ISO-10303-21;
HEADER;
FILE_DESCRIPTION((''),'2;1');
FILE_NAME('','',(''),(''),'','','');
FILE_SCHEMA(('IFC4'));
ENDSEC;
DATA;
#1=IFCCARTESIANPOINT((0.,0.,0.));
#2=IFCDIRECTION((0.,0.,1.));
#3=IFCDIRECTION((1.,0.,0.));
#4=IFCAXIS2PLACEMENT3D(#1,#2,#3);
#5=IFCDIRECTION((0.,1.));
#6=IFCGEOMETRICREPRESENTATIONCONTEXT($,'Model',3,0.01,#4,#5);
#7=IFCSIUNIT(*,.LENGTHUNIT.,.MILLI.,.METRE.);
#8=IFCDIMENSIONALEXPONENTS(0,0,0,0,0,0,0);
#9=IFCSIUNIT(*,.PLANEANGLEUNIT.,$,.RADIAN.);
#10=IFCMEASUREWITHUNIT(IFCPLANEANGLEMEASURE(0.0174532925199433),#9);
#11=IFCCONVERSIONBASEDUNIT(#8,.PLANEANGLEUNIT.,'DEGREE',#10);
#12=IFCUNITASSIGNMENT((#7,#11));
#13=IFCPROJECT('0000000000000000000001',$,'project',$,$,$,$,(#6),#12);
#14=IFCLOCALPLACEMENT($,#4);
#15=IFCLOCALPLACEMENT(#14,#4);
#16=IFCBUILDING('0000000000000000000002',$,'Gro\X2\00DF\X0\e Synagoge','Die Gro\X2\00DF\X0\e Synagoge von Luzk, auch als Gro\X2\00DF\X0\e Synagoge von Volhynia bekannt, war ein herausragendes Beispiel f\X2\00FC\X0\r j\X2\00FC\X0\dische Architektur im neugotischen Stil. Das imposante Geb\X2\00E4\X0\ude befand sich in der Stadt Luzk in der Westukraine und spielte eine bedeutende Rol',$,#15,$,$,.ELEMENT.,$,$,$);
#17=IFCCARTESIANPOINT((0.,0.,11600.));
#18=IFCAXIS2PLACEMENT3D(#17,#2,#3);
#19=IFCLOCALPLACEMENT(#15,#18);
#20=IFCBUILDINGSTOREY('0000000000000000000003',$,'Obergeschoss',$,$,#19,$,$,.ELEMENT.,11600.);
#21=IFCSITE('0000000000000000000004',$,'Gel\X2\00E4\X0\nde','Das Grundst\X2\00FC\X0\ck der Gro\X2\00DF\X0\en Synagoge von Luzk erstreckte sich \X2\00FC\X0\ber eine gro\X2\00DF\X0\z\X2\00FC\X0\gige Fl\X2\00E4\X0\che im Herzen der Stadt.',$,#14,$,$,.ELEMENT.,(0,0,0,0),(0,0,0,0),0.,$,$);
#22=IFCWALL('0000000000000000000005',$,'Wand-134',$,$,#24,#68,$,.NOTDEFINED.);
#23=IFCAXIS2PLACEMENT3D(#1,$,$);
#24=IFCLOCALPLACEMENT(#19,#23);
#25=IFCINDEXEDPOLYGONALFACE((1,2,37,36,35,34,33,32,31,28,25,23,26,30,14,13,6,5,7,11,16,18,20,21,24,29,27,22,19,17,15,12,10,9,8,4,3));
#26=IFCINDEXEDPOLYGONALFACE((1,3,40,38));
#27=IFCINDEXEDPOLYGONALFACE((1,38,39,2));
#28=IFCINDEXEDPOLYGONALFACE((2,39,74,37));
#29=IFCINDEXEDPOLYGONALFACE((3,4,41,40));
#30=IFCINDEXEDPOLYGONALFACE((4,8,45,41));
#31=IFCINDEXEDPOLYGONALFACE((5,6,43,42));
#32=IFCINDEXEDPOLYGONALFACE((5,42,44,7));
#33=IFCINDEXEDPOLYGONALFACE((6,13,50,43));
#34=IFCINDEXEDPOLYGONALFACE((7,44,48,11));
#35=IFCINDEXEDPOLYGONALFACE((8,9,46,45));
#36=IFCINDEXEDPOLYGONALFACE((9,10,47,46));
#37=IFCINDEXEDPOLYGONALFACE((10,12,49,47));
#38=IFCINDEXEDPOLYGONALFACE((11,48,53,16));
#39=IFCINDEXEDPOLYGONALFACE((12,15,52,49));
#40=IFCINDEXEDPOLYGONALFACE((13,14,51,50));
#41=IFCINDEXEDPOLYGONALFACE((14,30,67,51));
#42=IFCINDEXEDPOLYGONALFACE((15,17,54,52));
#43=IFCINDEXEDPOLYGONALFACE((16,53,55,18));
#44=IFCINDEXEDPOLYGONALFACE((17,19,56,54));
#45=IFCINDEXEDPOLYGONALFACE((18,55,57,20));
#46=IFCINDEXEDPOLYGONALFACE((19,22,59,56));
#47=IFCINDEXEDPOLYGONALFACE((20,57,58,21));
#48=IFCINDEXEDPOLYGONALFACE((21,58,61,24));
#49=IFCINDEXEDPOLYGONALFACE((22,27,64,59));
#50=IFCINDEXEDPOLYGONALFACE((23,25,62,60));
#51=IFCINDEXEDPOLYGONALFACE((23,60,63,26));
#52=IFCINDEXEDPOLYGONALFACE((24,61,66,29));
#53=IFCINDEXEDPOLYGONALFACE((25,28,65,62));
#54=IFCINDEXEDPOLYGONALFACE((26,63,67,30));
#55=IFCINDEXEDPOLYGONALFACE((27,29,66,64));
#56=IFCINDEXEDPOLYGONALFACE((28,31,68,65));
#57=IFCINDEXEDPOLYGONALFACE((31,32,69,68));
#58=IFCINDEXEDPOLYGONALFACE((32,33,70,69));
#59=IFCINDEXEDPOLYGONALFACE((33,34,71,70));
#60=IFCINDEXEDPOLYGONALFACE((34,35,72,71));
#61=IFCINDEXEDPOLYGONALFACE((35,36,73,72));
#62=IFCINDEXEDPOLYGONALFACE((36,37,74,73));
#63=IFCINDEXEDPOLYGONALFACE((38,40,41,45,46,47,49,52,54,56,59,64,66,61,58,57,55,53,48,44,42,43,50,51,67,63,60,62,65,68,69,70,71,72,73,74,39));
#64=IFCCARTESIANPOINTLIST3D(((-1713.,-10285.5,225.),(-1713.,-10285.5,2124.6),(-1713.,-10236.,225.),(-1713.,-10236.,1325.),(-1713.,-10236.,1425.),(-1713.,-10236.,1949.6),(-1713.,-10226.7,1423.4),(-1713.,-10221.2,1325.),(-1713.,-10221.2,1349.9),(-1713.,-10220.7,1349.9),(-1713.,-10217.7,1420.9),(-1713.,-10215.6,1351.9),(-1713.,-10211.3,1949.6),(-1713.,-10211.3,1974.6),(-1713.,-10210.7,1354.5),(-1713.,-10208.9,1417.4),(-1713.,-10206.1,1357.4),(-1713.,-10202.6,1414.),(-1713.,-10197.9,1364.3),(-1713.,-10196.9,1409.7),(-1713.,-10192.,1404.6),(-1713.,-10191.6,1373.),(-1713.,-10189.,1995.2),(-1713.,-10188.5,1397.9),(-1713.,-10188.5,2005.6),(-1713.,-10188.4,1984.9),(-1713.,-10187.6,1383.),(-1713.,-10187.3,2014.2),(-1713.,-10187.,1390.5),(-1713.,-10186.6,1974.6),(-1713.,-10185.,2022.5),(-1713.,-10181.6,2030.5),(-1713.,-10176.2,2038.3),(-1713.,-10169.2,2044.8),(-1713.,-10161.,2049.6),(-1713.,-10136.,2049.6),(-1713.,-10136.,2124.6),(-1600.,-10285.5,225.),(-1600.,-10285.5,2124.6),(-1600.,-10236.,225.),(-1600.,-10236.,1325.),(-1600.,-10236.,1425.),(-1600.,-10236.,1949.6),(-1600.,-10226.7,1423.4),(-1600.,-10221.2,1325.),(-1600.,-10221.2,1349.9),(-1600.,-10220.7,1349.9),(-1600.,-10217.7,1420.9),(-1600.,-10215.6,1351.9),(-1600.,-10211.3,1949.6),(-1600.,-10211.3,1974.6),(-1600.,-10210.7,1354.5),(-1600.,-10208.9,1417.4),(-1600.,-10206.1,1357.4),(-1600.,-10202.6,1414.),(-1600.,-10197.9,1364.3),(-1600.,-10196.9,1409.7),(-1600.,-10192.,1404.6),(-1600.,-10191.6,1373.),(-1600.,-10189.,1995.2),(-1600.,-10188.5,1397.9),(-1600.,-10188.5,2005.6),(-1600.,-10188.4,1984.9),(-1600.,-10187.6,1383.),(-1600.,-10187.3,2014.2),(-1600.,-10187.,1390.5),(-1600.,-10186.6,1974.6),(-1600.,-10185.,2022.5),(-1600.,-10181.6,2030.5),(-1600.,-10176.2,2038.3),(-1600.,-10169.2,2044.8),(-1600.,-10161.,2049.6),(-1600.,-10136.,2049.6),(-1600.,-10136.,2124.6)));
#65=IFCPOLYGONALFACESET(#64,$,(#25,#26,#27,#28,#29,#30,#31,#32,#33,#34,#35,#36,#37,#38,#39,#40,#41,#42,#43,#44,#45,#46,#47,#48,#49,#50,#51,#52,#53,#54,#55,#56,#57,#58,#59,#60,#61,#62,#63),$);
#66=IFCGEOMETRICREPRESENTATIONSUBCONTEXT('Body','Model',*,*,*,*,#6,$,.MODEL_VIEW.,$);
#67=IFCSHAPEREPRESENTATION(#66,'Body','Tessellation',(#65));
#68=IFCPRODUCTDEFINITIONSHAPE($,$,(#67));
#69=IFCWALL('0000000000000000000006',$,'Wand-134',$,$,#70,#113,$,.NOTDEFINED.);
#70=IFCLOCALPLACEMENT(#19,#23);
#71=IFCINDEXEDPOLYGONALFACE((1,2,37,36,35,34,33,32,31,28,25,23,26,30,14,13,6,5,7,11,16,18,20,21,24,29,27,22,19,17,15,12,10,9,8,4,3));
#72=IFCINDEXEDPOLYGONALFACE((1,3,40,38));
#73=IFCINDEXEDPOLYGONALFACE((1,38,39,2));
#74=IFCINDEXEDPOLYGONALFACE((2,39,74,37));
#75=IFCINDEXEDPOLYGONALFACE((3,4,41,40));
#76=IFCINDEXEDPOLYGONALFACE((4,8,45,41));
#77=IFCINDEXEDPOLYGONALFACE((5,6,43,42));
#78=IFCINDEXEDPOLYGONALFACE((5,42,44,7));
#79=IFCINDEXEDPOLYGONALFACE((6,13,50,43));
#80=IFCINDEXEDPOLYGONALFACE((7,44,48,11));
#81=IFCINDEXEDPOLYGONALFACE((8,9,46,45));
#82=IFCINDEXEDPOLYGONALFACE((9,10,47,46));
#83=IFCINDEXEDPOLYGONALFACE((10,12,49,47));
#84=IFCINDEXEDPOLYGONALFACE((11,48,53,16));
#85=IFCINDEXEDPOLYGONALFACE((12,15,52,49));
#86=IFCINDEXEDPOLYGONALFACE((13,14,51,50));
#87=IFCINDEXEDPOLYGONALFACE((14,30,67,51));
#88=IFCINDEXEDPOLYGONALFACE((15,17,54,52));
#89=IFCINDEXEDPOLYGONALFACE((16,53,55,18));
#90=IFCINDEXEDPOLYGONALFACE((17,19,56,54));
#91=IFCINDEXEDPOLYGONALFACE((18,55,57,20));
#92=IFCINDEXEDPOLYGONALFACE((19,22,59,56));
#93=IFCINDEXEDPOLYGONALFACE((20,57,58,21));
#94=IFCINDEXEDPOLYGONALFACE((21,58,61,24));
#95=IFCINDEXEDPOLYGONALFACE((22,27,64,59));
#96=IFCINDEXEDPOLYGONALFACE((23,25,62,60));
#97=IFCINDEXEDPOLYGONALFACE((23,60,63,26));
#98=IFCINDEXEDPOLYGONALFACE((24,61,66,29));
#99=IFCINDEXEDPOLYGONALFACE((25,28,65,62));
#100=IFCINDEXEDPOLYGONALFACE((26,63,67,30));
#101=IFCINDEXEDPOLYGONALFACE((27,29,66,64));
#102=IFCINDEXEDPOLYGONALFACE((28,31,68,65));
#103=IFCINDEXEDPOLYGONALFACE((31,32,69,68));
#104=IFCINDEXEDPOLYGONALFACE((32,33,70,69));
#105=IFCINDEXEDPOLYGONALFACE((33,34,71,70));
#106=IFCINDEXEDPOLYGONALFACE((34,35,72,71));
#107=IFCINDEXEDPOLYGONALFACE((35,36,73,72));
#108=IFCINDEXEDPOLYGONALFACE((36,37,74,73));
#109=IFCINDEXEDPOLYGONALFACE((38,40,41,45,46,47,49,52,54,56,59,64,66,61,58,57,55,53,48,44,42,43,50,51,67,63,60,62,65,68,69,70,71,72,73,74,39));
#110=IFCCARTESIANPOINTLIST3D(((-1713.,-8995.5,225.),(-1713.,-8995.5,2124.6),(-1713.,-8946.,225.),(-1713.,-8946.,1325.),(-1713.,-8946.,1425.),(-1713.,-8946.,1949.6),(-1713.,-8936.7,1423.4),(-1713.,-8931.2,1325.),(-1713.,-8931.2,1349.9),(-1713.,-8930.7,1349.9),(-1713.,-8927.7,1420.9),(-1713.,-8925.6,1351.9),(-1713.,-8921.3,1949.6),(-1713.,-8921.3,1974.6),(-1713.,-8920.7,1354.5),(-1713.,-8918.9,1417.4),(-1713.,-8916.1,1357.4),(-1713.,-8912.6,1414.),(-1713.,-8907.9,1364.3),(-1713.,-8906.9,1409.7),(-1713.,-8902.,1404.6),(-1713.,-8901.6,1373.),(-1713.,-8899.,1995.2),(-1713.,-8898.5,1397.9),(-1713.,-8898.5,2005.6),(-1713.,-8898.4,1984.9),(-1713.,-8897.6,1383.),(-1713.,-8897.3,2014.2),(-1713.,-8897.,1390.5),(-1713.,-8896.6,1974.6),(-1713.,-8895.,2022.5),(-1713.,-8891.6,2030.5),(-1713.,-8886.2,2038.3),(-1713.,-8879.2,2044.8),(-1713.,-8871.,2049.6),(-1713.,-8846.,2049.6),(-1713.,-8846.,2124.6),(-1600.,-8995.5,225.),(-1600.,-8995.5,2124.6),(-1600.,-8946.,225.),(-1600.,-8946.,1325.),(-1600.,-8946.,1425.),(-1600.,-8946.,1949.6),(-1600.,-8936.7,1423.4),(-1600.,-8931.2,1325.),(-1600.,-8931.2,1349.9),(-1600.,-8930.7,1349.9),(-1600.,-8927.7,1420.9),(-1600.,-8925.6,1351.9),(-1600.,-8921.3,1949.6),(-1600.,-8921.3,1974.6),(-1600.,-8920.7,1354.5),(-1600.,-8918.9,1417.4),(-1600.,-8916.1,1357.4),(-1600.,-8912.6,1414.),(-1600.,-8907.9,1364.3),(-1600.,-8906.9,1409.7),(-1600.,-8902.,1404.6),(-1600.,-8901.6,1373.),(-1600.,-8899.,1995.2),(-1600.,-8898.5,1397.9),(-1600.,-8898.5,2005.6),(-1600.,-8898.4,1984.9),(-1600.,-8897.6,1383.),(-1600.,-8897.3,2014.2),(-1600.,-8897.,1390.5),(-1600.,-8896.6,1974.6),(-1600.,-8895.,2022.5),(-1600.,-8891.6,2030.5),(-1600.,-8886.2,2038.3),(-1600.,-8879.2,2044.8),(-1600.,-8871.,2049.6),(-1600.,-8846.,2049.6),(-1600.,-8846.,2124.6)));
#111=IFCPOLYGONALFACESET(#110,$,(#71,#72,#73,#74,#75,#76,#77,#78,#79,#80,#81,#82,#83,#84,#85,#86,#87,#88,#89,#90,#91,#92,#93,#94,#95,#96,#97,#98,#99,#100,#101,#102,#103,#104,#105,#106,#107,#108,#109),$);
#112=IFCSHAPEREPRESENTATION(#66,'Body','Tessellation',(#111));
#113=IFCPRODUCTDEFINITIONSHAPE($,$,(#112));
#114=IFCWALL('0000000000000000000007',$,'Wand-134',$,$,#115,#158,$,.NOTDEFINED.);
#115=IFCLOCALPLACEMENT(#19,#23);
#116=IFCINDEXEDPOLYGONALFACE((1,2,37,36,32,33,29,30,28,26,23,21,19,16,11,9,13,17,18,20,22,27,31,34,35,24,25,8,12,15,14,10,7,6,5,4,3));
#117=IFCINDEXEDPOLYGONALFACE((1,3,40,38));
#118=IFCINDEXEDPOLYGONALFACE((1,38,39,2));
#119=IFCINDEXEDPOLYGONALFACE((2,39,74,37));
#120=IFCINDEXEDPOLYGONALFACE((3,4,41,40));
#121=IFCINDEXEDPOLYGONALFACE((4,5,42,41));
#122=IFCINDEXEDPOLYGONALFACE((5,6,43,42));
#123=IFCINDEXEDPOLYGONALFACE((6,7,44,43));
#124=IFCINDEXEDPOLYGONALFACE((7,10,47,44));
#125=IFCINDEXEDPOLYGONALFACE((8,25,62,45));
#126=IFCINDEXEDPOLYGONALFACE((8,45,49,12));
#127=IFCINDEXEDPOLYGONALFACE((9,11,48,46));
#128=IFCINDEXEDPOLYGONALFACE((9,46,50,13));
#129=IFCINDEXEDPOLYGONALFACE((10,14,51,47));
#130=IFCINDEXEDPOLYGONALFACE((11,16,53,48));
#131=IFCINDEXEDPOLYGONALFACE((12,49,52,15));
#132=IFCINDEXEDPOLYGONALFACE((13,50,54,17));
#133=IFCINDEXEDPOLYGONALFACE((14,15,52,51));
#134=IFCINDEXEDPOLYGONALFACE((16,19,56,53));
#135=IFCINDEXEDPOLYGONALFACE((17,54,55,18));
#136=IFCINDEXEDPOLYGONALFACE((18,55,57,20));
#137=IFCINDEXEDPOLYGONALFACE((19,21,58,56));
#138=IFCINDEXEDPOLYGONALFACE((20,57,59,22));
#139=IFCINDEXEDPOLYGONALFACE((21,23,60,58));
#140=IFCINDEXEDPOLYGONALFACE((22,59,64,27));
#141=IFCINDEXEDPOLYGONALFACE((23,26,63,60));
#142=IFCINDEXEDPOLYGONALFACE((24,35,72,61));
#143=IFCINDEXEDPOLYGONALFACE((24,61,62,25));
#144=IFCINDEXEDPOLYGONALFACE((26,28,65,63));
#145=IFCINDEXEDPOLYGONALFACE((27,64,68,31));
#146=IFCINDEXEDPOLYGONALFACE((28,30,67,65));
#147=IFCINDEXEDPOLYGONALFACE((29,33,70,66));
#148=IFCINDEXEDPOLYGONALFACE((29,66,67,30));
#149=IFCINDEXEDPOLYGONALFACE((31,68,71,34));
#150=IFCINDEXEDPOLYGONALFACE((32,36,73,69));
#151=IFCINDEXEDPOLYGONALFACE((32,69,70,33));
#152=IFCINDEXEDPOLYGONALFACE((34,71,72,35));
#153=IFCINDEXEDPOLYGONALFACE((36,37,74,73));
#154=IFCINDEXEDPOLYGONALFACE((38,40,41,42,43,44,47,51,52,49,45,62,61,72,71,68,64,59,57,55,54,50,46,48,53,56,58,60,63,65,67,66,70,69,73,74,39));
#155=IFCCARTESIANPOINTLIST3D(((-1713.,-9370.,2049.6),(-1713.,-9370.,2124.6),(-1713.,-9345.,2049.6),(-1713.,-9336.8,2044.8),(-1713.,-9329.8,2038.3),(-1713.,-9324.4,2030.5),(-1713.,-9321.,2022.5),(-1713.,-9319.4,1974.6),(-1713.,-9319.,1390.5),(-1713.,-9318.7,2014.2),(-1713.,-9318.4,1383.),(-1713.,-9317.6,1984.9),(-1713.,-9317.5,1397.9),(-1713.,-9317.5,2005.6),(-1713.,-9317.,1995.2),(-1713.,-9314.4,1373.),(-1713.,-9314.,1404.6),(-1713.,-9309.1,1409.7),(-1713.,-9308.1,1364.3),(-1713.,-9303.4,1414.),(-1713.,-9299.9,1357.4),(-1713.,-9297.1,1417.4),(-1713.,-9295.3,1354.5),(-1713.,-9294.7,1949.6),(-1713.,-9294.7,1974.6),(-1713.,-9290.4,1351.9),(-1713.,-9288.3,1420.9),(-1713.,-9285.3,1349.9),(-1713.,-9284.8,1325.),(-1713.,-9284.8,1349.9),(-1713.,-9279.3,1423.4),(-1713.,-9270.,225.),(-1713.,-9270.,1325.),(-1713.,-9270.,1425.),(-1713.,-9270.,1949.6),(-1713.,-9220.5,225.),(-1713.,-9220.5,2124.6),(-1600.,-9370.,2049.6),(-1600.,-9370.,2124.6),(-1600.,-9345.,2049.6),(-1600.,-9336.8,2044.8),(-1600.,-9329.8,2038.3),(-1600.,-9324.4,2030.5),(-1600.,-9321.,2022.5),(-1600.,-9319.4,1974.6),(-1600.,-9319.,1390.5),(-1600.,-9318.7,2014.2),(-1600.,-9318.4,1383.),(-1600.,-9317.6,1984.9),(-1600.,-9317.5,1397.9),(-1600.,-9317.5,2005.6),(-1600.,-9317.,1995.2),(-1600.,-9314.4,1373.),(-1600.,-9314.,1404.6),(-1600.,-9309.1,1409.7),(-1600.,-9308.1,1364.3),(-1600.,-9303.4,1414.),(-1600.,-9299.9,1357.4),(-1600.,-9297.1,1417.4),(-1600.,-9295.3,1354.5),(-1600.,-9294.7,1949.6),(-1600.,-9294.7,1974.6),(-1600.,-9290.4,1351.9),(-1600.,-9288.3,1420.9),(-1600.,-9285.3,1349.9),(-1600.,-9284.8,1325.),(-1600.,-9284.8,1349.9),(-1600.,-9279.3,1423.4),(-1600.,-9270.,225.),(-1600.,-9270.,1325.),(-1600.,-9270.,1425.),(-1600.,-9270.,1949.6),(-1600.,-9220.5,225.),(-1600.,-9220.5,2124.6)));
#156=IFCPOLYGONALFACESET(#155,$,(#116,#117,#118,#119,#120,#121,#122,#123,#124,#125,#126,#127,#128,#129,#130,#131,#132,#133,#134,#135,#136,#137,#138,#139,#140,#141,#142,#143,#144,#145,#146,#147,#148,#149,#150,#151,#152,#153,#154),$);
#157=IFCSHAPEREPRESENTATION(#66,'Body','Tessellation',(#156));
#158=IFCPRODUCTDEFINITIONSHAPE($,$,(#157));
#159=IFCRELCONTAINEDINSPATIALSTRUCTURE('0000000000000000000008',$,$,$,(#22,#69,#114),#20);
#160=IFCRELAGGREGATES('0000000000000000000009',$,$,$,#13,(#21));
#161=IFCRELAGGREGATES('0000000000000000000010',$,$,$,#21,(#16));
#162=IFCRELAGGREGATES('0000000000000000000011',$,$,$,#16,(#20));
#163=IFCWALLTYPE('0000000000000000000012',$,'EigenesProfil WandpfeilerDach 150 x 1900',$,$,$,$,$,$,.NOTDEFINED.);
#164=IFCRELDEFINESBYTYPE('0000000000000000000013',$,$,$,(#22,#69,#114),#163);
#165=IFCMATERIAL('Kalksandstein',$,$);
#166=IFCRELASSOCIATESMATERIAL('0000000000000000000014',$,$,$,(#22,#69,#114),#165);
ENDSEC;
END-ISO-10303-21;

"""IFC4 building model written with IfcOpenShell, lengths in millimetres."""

from ifc_helpers import new_model, entity, si_unit, converted_unit, direction, frame, origin_with_axes, place, context, subcontext, project, spatial, line, arc, indexed_curve, outline, extrude, material, material_profile, profile_set, type_object, element, save


model = new_model("IFC4")

# Units and contexts
model_context = context("Model", 3, precision=0.01, world=origin_with_axes(), true_north=direction((0.0, 1.0)))
body_context = subcontext(model_context, "Body", "Model", "MODEL_VIEW")
ifc_project = project(units=[si_unit("LENGTHUNIT", "METRE", prefix="MILLI"), converted_unit("PLANEANGLEUNIT", "DEGREE", entity("IfcPlaneAngleMeasure", 0.0174532925199433), si_unit("PLANEANGLEUNIT", "RADIAN"), dimensions=[0, 0, 0, 0, 0, 0, 0])], contexts=[model_context])

# Site, building, storey
site_placement = place(None, origin_with_axes())
site = spatial("IfcSite", under=ifc_project, at=site_placement, Name="Gelände", Description="Das Grundstück der Großen Synagoge von Luzk erstreckte sich über eine großzügige Fläche im Herzen der Stadt.", CompositionType="ELEMENT", RefLatitude=(0, 0, 0, 0), RefLongitude=(0, 0, 0, 0), RefElevation=0.0)
building_placement = place(site_placement, origin_with_axes())
building = spatial("IfcBuilding", under=site, at=building_placement, Name="Große Synagoge", Description="Die Große Synagoge von Luzk, auch als Große Synagoge von Volhynia bekannt, war ein herausragendes Beispiel für jüdische Architektur im neugotischen Stil. Das imposante Gebäude befand sich in der Stadt Luzk in der Westukraine und spielte eine bedeutende Rol", CompositionType="ELEMENT")
storey_placement = place(building_placement, frame((0.0, 0.0, 11600.0), z_axis=(0.0, 0.0, 1.0), x_axis=(1.0, 0.0, 0.0)))
storey = spatial("IfcBuildingStorey", under=building, at=storey_placement, Name="Obergeschoss", CompositionType="ELEMENT", Elevation=11600.0)

# Walls
ifc_material_1 = material(Name="Kalksandstein")
ifc_material_profile = material_profile(ifc_material_1, outline(indexed_curve([(74.2, 1749.6), (98.9, 1749.6), (96.7, 1765.0), (97.0, 1780.5), (99.2, 1793.4), (103.9, 1805.5), (112.6, 1816.7), (124.5, 1824.6), (149.5, 1824.6), (149.5, 1899.6), (0.0, 1899.6), (0.0, 0.0), (49.5, 0.0), (49.5, 1100.0), (64.3, 1100.0), (64.3, 1124.9), (64.8, 1124.9), (72.4, 1128.1), (79.4, 1132.4), (91.1, 1143.4), (97.9, 1157.9), (98.0, 1169.2), (93.5, 1179.5), (85.8, 1187.0), (76.6, 1192.3), (63.3, 1197.2), (49.5, 1200.0), (49.5, 1724.6), (74.2, 1724.6)], segments=[line(1, 2), arc(2, 3, 4), arc(4, 5, 6), arc(6, 7, 8), line(8, 9, 10, 11, 12, 13, 14, 15, 16, 17), arc(17, 18, 19), arc(19, 20, 21), arc(21, 22, 23), arc(23, 24, 25), arc(25, 26, 27), line(27, 28, 29, 1)])), Name="Kalksandstein")
ifc_profile_set = profile_set([ifc_material_profile], Name="EigenesProfil WandpfeilerDach")
wall_type_1 = type_object("IfcWallType", Name="EigenesProfil WandpfeilerDach 150 x 1900", PredefinedType="NOTDEFINED")
for number, where, z_axis, x_axis, name in (
    (1, (-1713.0, -10285.5, 225.0), (0.0, 0.0, 1.0), (1.0, 0.0, 0.0), "Wand-134"),
    (2, (-1713.0, -8995.5, 225.0), (0.0, 0.0, 1.0), (1.0, 0.0, 0.0), "Wand-134"),
):
    element("IfcWall", number, at=place(storey_placement, frame(where, z_axis=z_axis, x_axis=x_axis)), inside=storey, type_object=wall_type_1, material=ifc_profile_set, Name=name, PredefinedType="NOTDEFINED", context=body_context, shape_type="SweptSolid", body=[
        extrude(outline(indexed_curve([(74.2, 1749.6), (98.9, 1749.6), (96.7, 1765.0), (97.0, 1780.5), (99.2, 1793.4), (103.9, 1805.5), (112.6, 1816.7), (124.5, 1824.6), (149.5, 1824.6), (149.5, 1899.6), (0.0, 1899.6), (0.0, 0.0), (49.5, 0.0), (49.5, 1100.0), (64.3, 1100.0), (64.3, 1124.9), (64.8, 1124.9), (72.4, 1128.1), (79.4, 1132.4), (91.1, 1143.4), (97.9, 1157.9), (98.0, 1169.2), (93.5, 1179.5), (85.8, 1187.0), (76.6, 1192.3), (63.3, 1197.2), (49.5, 1200.0), (49.5, 1724.6), (74.2, 1724.6)], segments=[line(1, 2), arc(2, 3, 4), arc(4, 5, 6), arc(6, 7, 8), line(8, 9, 10, 11, 12, 13, 14, 15, 16, 17), arc(17, 18, 19), arc(19, 20, 21), arc(21, 22, 23), arc(23, 24, 25), arc(25, 26, 27), line(27, 28, 29, 1)])), frame((0.0, 0.0, 0.0), z_axis=(1.0, 0.0, 0.0), x_axis=(0.0, 1.0, 0.0)), (0.0, 0.0, 1.0), 113.0),
    ])
wall_1_placement = place(storey_placement, frame((-1713.0, -9220.5, 225.0), z_axis=(0.0, 0.0, 1.0), x_axis=(1.0, 0.0, 0.0)))
element("IfcWall", 3, at=wall_1_placement, inside=storey, type_object=wall_type_1, material=ifc_profile_set, Name="Wand-134", PredefinedType="NOTDEFINED", context=body_context, shape_type="SweptSolid", body=[
    extrude(outline(indexed_curve([(74.2, 1749.6), (98.9, 1749.6), (96.7, 1765.0), (97.0, 1780.5), (99.2, 1793.4), (103.9, 1805.5), (112.6, 1816.7), (124.5, 1824.6), (149.5, 1824.6), (149.5, 1899.6), (0.0, 1899.6), (0.0, 0.0), (49.5, 0.0), (49.5, 1100.0), (64.3, 1100.0), (64.3, 1124.9), (64.8, 1124.9), (72.4, 1128.1), (79.4, 1132.4), (91.1, 1143.4), (97.9, 1157.9), (98.0, 1169.2), (93.5, 1179.5), (85.8, 1187.0), (76.6, 1192.3), (63.3, 1197.2), (49.5, 1200.0), (49.5, 1724.6), (74.2, 1724.6)], segments=[line(1, 2), arc(2, 3, 4), arc(4, 5, 6), arc(6, 7, 8), line(8, 9, 10, 11, 12, 13, 14, 15, 16, 17), arc(17, 18, 19), arc(19, 20, 21), arc(21, 22, 23), arc(23, 24, 25), arc(25, 26, 27), line(27, 28, 29, 1)])), frame((0.0, 0.0, 0.0), z_axis=(-1.0, 0.0, 0.0), x_axis=(0.0, -1.0, 0.0)), (0.0, 0.0, -1.0), 113.0),
])

save(model, "model.ifc")
